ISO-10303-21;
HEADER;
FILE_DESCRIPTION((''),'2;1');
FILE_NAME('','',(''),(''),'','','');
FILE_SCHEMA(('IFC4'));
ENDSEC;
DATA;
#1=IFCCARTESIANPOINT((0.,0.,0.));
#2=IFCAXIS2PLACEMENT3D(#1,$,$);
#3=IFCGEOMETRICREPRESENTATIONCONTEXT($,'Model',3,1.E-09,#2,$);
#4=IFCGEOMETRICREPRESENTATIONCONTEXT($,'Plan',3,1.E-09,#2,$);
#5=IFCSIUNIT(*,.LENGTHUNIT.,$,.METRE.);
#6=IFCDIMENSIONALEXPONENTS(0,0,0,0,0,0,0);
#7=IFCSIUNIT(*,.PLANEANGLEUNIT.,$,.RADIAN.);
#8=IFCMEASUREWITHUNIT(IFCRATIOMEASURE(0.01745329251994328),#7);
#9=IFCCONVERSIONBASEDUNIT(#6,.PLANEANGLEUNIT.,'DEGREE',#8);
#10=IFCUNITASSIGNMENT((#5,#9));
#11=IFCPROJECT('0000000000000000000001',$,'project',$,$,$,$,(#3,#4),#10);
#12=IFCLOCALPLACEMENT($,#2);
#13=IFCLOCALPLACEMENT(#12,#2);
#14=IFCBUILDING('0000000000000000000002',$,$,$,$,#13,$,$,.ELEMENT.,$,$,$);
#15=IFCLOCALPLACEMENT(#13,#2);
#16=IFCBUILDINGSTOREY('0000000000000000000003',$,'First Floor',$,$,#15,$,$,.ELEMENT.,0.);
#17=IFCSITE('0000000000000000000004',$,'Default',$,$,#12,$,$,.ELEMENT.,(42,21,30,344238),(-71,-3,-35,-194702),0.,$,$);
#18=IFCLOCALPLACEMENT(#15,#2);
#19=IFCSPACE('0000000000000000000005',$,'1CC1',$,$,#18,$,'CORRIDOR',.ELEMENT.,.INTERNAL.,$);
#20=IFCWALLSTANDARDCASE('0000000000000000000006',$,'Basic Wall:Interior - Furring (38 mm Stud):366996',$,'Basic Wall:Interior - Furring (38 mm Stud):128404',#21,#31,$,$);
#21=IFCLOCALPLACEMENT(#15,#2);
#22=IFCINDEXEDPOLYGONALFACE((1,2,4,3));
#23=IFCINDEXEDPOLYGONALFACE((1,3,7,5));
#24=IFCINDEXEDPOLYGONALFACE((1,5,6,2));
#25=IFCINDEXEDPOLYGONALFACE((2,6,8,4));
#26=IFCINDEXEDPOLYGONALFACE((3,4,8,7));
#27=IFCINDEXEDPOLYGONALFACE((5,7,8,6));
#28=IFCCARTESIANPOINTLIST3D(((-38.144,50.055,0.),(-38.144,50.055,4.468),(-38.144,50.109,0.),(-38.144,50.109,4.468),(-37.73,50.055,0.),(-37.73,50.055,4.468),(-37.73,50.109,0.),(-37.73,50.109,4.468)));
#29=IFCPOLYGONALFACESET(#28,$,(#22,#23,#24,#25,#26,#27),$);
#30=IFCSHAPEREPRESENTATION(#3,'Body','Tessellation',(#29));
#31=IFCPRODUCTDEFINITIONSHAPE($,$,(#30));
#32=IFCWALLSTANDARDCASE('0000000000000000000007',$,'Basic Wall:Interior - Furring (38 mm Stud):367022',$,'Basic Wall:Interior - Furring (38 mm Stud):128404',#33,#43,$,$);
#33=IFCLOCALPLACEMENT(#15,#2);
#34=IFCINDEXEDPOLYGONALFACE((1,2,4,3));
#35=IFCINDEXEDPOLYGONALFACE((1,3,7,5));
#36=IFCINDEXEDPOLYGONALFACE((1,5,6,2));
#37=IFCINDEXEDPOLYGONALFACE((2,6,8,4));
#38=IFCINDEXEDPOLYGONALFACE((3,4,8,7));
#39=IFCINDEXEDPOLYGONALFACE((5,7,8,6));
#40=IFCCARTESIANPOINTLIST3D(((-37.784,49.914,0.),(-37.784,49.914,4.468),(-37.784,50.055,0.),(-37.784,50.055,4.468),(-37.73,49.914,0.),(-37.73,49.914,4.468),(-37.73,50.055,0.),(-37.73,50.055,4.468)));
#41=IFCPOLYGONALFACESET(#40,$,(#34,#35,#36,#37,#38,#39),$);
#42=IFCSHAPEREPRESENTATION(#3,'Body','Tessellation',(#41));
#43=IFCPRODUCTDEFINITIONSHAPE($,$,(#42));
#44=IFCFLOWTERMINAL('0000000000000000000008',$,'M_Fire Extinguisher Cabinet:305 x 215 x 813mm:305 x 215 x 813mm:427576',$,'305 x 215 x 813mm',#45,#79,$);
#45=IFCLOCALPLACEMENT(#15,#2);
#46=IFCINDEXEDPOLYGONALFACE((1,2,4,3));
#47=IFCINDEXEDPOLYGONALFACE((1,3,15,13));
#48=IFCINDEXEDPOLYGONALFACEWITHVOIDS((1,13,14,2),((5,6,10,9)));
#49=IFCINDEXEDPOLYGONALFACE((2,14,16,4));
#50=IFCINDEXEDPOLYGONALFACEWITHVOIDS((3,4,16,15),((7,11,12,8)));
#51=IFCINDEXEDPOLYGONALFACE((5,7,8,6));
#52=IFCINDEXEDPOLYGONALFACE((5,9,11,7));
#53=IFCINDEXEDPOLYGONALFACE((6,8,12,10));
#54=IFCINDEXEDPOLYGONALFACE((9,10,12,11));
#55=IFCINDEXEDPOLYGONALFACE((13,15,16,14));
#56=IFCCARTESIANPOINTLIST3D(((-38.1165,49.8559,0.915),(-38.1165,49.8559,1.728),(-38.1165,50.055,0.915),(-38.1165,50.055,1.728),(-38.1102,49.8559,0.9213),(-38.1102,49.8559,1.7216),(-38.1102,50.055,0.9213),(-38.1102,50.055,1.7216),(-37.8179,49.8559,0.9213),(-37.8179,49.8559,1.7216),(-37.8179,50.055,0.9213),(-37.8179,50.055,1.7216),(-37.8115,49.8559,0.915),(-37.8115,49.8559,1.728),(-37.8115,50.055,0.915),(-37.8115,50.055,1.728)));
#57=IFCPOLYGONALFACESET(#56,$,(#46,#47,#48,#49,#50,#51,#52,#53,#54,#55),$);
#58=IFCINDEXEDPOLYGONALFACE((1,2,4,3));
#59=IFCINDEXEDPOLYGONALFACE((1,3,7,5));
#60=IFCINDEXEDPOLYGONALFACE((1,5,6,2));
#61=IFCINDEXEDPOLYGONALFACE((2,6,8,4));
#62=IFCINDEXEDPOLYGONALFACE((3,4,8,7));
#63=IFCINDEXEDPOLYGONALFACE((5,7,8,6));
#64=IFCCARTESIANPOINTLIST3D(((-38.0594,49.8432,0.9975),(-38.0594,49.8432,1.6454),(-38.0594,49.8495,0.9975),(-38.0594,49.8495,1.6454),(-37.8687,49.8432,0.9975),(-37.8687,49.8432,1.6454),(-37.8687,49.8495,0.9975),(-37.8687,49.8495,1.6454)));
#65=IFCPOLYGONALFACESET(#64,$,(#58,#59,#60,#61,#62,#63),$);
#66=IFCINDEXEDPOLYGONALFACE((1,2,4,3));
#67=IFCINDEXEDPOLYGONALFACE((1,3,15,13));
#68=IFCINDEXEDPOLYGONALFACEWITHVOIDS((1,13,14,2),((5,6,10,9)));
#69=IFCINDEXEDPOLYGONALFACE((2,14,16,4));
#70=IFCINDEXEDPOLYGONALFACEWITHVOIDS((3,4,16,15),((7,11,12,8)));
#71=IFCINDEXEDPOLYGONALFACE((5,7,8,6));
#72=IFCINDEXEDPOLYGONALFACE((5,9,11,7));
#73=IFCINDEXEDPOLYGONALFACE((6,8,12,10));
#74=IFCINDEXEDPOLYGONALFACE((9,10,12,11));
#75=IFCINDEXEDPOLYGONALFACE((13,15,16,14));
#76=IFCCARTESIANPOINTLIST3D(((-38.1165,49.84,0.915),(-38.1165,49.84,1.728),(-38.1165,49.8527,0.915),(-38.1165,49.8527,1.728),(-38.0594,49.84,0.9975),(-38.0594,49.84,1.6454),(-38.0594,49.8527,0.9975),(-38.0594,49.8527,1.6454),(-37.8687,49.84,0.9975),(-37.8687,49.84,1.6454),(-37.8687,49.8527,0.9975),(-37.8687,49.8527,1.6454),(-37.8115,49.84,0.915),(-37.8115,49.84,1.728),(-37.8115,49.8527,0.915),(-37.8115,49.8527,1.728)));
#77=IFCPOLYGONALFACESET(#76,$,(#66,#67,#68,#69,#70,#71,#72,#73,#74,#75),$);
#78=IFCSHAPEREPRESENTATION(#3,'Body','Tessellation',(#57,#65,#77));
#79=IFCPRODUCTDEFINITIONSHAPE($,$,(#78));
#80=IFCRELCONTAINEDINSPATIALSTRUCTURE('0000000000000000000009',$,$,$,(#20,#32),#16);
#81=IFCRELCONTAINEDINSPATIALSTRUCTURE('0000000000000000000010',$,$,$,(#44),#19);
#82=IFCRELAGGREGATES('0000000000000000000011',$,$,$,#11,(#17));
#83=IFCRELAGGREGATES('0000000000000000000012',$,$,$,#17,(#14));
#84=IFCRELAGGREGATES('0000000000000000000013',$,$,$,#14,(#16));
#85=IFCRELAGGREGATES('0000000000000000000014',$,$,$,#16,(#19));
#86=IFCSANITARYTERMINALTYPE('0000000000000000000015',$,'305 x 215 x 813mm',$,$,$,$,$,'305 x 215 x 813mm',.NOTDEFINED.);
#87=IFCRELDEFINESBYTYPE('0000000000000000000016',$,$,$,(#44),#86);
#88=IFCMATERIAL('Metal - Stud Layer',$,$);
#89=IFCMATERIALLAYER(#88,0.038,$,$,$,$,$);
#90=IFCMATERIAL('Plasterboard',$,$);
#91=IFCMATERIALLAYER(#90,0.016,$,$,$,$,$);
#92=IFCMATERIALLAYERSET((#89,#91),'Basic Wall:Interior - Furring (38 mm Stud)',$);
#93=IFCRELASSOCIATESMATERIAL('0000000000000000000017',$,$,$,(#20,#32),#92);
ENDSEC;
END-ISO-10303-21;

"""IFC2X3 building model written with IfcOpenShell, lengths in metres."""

from ifc_helpers import new_model, entity, si_unit, converted_unit, frame, frame_2d, origin, origin_2d_with_axis, place, context, project, spatial, polyline, rectangle, outline, extrude, source, transform, mapped, material, layer, layer_set, layer_usage, type_object, type_shapes, element, save


model = new_model("IFC2X3")

# Units and contexts
model_context = context("Model", 3, precision=1e-09, world=origin())
plan_context = context("Plan", 3, precision=1e-09, world=origin())
ifc_project = project(units=[si_unit("LENGTHUNIT", "METRE"), converted_unit("PLANEANGLEUNIT", "DEGREE", entity("IfcRatioMeasure", 0.01745329251994328), si_unit("PLANEANGLEUNIT", "RADIAN"), dimensions=[0, 0, 0, 0, 0, 0, 0])], contexts=[model_context, plan_context])

# Site, building, storey
site_placement = place(None, origin())
site = spatial("IfcSite", under=ifc_project, at=site_placement, Name="Default", CompositionType="ELEMENT", RefLatitude=(42, 21, 30, 344238), RefLongitude=(-71, -3, -35, -194702), RefElevation=0.0)
building_placement = place(site_placement, origin())
building = spatial("IfcBuilding", under=site, at=building_placement, CompositionType="ELEMENT")
storey_placement = place(building_placement, origin())
storey = spatial("IfcBuildingStorey", under=building, at=storey_placement, Name="First Floor", CompositionType="ELEMENT", Elevation=0.0)

# Shared definitions
ifc_material_1 = material(Name="Plasterboard")
ifc_layer_1 = layer(ifc_material_1, 0.016)
ifc_material_2 = material(Name="Metal - Stud Layer")

# Shared definitions
ifc_layer_2 = layer(ifc_material_2, 0.038)
ifc_layer_set_1 = layer_set([ifc_layer_2, ifc_layer_1], Name="Basic Wall:Interior - Furring (38 mm Stud)")
ifc_layer_usage_1 = layer_usage(ifc_layer_set_1, "AXIS2", "NEGATIVE", 0.027)

# Walls
wall_1_placement = place(storey_placement, frame((-38.144, 50.082, 0.0)))
element("IfcWallStandardCase", 1, at=wall_1_placement, inside=storey, material=ifc_layer_usage_1, Name="Basic Wall:Interior - Furring (38 mm Stud):366996", ObjectType="Basic Wall:Interior - Furring (38 mm Stud):128404", context=model_context, shape_type="SweptSolid", body=[
    extrude(rectangle(XDim=0.414, YDim=0.054, at=frame_2d((0.207, 0.0), x_axis=(-1.0, 0.0))), origin(), (0.0, 0.0, 1.0), 4.468),
])
wall_2_placement = place(storey_placement, frame((-37.757, 50.055, 0.0), z_axis=(0.0, 0.0, 1.0), x_axis=(0.0, -1.0, 0.0)))
element("IfcWallStandardCase", 2, at=wall_2_placement, inside=storey, material=ifc_layer_usage_1, Name="Basic Wall:Interior - Furring (38 mm Stud):367022", ObjectType="Basic Wall:Interior - Furring (38 mm Stud):128404", context=model_context, shape_type="SweptSolid", body=[
    extrude(rectangle(XDim=0.141, YDim=0.054, at=frame_2d((0.0705, 0.0), x_axis=(-1.0, 0.0))), origin(), (0.0, 0.0, 1.0), 4.468),
])

# Shared definitions
space_placement = place(storey_placement, origin())
space = spatial("IfcSpace", under=storey, at=space_placement, Name="1CC1", LongName="CORRIDOR", CompositionType="ELEMENT", InteriorOrExteriorSpace="INTERNAL")

# Flow terminal
sanitary_terminal_type = type_object("IfcSanitaryTerminalType", Name="305 x 215 x 813mm", ElementType="305 x 215 x 813mm", PredefinedType="NOTDEFINED")
shared_shape_1 = source(origin(), model_context, "Body", "SweptSolid", [
    extrude(outline(polyline([(-0.1525, -0.4065), (0.1525, -0.4065), (0.1525, 0.4065), (-0.1525, 0.4065), (-0.1525, -0.4065)]), holes=[polyline([(-0.1462, -0.4001), (-0.1462, 0.4002), (0.1462, 0.4002), (0.1462, -0.4001), (-0.1462, -0.4001)])]), frame((-0.1096, 0.027, 1.3215), z_axis=(0.0, 1.0, 0.0), x_axis=(1.0, 0.0, 0.0)), (0.0, 0.0, 1.0), 0.1991),
    extrude(rectangle(XDim=0.0064, YDim=0.1907, at=origin_2d_with_axis()), frame((-0.1096, 0.2356, 0.9975), z_axis=(0.0, 0.0, 1.0), x_axis=(0.0, -1.0, 0.0)), (0.0, 0.0, 1.0), 0.6479),
    extrude(outline(polyline([(-0.1525, -0.4065), (0.1525, -0.4065), (0.1525, 0.4065), (-0.1525, 0.4065), (-0.1525, -0.4065)]), holes=[polyline([(-0.0953, -0.3239), (-0.0953, 0.324), (0.0954, 0.324), (0.0954, -0.3239), (-0.0953, -0.3239)])]), frame((-0.1096, 0.2293, 1.3215), z_axis=(0.0, 1.0, 0.0), x_axis=(1.0, 0.0, 0.0)), (0.0, 0.0, 1.0), 0.0127),
])
type_shapes(sanitary_terminal_type, [shared_shape_1])
flow_terminal_placement = place(space_placement, frame((-38.0736, 50.082, 0.0), z_axis=(0.0, 0.0, 1.0), x_axis=(-1.0, 0.0, 0.0)))
element("IfcFlowTerminal", 3, at=flow_terminal_placement, inside=space, type_object=sanitary_terminal_type, Name="M_Fire Extinguisher Cabinet:305 x 215 x 813mm:305 x 215 x 813mm:427576", ObjectType="305 x 215 x 813mm", context=model_context, shape_type="MappedRepresentation", body=[
    mapped(shared_shape_1, transform((0.0, 0.0, 0.0), scale=1.0)),
])

save(model, "model.ifc")
